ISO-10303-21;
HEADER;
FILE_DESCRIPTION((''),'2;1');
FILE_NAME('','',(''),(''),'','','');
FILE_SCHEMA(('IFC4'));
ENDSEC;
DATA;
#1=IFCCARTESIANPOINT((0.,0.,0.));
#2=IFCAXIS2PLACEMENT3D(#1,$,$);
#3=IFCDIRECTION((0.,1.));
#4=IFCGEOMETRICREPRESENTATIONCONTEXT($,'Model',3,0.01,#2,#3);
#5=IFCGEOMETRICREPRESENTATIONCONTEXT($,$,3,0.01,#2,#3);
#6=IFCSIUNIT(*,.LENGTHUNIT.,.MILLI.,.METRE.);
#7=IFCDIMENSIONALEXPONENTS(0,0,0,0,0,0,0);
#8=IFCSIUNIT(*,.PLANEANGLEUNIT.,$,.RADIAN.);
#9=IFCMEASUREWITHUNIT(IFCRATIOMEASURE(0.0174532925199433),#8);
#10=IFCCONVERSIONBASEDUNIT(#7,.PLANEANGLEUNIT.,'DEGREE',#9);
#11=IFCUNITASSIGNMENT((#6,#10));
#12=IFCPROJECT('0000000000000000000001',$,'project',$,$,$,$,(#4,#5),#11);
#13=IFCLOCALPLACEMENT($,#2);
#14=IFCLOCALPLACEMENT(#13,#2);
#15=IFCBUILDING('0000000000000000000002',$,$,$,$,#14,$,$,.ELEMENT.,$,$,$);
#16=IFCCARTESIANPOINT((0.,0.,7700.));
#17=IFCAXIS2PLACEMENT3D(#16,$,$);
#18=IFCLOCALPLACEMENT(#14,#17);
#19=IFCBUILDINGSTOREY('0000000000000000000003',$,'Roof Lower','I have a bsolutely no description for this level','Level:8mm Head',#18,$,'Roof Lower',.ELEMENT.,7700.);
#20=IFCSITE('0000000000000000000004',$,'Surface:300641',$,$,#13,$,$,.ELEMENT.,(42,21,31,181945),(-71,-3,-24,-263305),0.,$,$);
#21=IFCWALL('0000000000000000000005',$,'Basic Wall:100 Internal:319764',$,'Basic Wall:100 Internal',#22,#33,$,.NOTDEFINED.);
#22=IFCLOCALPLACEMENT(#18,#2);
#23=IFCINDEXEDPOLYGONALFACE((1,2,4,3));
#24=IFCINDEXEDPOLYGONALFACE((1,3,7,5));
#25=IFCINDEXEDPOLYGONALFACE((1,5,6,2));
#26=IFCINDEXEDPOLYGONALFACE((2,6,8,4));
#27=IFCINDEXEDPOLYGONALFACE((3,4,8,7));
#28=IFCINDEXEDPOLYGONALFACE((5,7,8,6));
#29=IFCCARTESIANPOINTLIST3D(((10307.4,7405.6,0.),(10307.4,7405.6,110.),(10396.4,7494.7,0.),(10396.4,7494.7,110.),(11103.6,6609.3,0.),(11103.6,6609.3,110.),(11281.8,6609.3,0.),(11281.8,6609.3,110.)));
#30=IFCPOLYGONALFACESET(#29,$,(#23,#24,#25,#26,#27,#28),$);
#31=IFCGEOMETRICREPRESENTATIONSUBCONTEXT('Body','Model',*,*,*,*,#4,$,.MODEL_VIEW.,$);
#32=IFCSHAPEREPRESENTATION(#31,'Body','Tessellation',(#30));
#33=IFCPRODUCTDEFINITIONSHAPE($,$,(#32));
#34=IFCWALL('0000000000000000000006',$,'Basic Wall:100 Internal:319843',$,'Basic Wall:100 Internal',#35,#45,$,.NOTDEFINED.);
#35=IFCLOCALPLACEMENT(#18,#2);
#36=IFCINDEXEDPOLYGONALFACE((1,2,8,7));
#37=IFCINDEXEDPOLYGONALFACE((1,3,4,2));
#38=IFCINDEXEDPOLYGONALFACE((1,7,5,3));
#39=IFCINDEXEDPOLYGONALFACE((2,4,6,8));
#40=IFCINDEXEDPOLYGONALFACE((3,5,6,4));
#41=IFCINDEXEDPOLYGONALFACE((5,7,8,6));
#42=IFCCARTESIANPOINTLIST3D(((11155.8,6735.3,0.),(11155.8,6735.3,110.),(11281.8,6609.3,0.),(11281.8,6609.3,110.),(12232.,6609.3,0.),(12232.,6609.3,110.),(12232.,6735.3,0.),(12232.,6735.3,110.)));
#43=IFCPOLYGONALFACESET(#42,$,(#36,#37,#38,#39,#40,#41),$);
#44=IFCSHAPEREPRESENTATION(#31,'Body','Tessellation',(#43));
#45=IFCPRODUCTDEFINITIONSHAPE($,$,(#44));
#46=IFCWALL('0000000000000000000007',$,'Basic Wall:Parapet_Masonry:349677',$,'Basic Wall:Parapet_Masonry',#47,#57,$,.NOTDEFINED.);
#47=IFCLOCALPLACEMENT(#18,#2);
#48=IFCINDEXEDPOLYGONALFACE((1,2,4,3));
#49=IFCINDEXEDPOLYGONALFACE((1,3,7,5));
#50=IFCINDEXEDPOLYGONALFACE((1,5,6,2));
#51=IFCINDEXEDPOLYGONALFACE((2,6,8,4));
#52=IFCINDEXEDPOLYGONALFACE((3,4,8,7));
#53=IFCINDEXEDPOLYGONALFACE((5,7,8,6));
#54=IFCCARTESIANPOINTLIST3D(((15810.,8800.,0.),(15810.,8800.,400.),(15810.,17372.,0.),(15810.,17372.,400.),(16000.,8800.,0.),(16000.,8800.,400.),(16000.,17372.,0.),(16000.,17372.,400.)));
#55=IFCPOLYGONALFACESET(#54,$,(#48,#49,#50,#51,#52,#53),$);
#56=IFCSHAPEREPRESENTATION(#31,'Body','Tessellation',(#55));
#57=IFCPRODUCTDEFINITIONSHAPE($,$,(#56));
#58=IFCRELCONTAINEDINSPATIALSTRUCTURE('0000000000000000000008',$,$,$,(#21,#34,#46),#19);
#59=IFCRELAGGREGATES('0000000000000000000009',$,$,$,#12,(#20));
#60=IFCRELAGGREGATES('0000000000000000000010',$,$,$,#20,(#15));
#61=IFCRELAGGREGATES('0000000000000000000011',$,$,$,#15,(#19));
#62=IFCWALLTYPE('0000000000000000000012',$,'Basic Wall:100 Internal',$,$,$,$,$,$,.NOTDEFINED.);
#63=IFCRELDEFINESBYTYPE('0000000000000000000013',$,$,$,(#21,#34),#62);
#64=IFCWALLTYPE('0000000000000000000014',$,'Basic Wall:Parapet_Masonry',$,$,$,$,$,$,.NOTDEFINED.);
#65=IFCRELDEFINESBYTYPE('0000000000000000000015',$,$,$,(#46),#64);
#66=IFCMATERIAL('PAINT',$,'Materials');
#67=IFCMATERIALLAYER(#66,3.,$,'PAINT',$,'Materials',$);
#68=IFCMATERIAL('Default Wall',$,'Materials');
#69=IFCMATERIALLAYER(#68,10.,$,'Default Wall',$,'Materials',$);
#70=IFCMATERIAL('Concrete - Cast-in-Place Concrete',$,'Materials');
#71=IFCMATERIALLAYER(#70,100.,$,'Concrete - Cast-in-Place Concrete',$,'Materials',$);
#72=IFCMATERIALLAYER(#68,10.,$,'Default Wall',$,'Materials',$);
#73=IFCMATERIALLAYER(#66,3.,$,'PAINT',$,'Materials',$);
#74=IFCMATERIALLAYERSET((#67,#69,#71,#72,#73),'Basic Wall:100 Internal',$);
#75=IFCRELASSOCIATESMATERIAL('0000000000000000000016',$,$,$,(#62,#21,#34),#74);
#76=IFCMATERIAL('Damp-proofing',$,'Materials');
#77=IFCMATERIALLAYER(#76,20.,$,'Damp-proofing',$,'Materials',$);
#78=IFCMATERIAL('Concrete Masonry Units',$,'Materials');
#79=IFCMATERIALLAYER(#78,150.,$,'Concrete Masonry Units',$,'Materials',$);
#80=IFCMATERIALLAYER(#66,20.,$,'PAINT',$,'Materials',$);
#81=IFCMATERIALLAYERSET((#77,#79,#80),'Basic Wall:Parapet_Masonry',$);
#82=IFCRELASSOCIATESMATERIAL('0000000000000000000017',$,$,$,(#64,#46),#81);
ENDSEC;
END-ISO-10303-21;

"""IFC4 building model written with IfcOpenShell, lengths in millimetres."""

from ifc_helpers import new_model, entity, si_unit, converted_unit, direction, frame, frame_2d, origin, place, context, subcontext, project, spatial, polyline, rectangle, outline, extrude, clip, halfspace, bounded_halfspace, material, layer, layer_set, layer_usage, type_object, element, save


model = new_model("IFC4")

# Units and contexts
model_context = context("Model", 3, precision=0.01, world=origin(), true_north=direction((0.0, 1.0)))
context_of_model = context(None, 3, precision=0.01, world=origin(), true_north=direction((0.0, 1.0)))
body_context = subcontext(model_context, "Body", "Model", "MODEL_VIEW")
ifc_project = project(units=[si_unit("LENGTHUNIT", "METRE", prefix="MILLI"), converted_unit("PLANEANGLEUNIT", "DEGREE", entity("IfcRatioMeasure", 0.0174532925199433), si_unit("PLANEANGLEUNIT", "RADIAN"), dimensions=[0, 0, 0, 0, 0, 0, 0])], contexts=[model_context, context_of_model])

# Site, building, storey
site_placement = place(None, origin())
site = spatial("IfcSite", under=ifc_project, at=site_placement, Name="Surface:300641", CompositionType="ELEMENT", RefLatitude=(42, 21, 31, 181945), RefLongitude=(-71, -3, -24, -263305), RefElevation=0.0)
building_placement = place(site_placement, origin())
building = spatial("IfcBuilding", under=site, at=building_placement, CompositionType="ELEMENT")
storey_placement = place(building_placement, frame((0.0, 0.0, 7700.0)))
storey = spatial("IfcBuildingStorey", under=building, at=storey_placement, Name="Roof Lower", Description="I have a bsolutely no description for this level", ObjectType="Level:8mm Head", LongName="Roof Lower", CompositionType="ELEMENT", Elevation=7700.0)

# Shared definitions
ifc_material_1 = material(Name="Concrete - Cast-in-Place Concrete", Category="Materials")

# Shared definitions
ifc_material_2 = material(Name="Damp-proofing", Category="Materials")

# Walls
ifc_material_3 = material(Name="PAINT", Category="Materials")
ifc_material_4 = material(Name="Default Wall", Category="Materials")
ifc_layer_1 = layer(ifc_material_3, 3.0, Name="PAINT", Category="Materials")
ifc_layer_2 = layer(ifc_material_4, 10.0, Name="Default Wall", Category="Materials")
ifc_layer_3 = layer(ifc_material_1, 100.0, Name="Concrete - Cast-in-Place Concrete", Category="Materials")
ifc_layer_4 = layer(ifc_material_4, 10.0, Name="Default Wall", Category="Materials")
ifc_layer_5 = layer(ifc_material_3, 3.0, Name="PAINT", Category="Materials")
ifc_layer_set_1 = layer_set([ifc_layer_1, ifc_layer_2, ifc_layer_3, ifc_layer_4, ifc_layer_5], Name="Basic Wall:100 Internal")
wall_type_1 = type_object("IfcWallType", Name="Basic Wall:100 Internal", PredefinedType="NOTDEFINED", material=ifc_layer_set_1)
ifc_layer_usage_1 = layer_usage(ifc_layer_set_1, "AXIS2", "NEGATIVE", 63.0)
wall_1_placement = place(storey_placement, frame((10351.9, 7450.1, 0.0), z_axis=(0.0, 0.0, 1.0), x_axis=(0.707107, -0.707107, 0.0)))
element("IfcWall", 1, at=wall_1_placement, inside=storey, type_object=wall_type_1, material=ifc_layer_usage_1, Name="Basic Wall:100 Internal:319764", ObjectType="Basic Wall:100 Internal", PredefinedType="NOTDEFINED", context=body_context, shape_type="Clipping", body=[
    clip(clip(extrude(outline(polyline([(1126.1, -63.0), (1252.1, 63.0), (1073.9, 63.0), (0.0, 63.0), (0.0, -63.0), (1126.1, -63.0)])), origin(), (0.0, 0.0, 1.0), 110.0), bounded_halfspace(frame((0.0, -63.0, 110.0), z_axis=(0.0, 0.0, -1.0), x_axis=(0.707107, 0.707107, 0.0)), True, frame((0.0, -63.0, 110.0)), polyline([(0.0, 0.0), (1126.1, 0.0), (1252.1, 126.0), (1073.9, 126.0), (0.0, 126.0), (0.0, 0.0)]))), halfspace(frame((0.0, 0.0, -3500.0)), True)),
])
ifc_layer_usage_2 = layer_usage(ifc_layer_set_1, "AXIS2", "NEGATIVE", 63.0)
wall_2_placement = place(storey_placement, frame((11155.8, 6672.3, 0.0)))
element("IfcWall", 2, at=wall_2_placement, inside=storey, type_object=wall_type_1, material=ifc_layer_usage_2, Name="Basic Wall:100 Internal:319843", ObjectType="Basic Wall:100 Internal", PredefinedType="NOTDEFINED", context=body_context, shape_type="Clipping", body=[
    clip(clip(extrude(outline(polyline([(126.0, -63.0), (1076.2, -63.0), (1076.2, 63.0), (0.0, 63.0), (126.0, -63.0)])), origin(), (0.0, 0.0, 1.0), 110.0), bounded_halfspace(frame((126.0, -63.0, 110.0), z_axis=(0.0, 0.0, -1.0), x_axis=(1.0, 0.0, 0.0)), True, frame((126.0, -63.0, 110.0)), polyline([(0.0, 0.0), (950.2, 0.0), (950.2, 126.0), (-126.0, 126.0), (0.0, 0.0)]))), halfspace(frame((0.0, 0.0, -3500.0)), True)),
])
ifc_layer_6 = layer(ifc_material_2, 20.0, Name="Damp-proofing", Category="Materials")
ifc_material_5 = material(Name="Concrete Masonry Units", Category="Materials")
ifc_layer_7 = layer(ifc_material_5, 150.0, Name="Concrete Masonry Units", Category="Materials")
ifc_layer_8 = layer(ifc_material_3, 20.0, Name="PAINT", Category="Materials")
ifc_layer_set_2 = layer_set([ifc_layer_6, ifc_layer_7, ifc_layer_8], Name="Basic Wall:Parapet_Masonry")
ifc_layer_usage_3 = layer_usage(ifc_layer_set_2, "AXIS2", "NEGATIVE", 95.0)
wall_type_2 = type_object("IfcWallType", Name="Basic Wall:Parapet_Masonry", PredefinedType="NOTDEFINED", material=ifc_layer_set_2)
wall_3_placement = place(storey_placement, frame((15905.0, 8800.0, 0.0), z_axis=(0.0, 0.0, 1.0), x_axis=(0.0, 1.0, 0.0)))
element("IfcWall", 3, at=wall_3_placement, inside=storey, type_object=wall_type_2, material=ifc_layer_usage_3, Name="Basic Wall:Parapet_Masonry:349677", ObjectType="Basic Wall:Parapet_Masonry", PredefinedType="NOTDEFINED", context=body_context, shape_type="Clipping", body=[
    clip(extrude(rectangle(XDim=8572.0, YDim=190.0, at=frame_2d((4286.0, 0.0), x_axis=(-1.0, 0.0))), origin(), (0.0, 0.0, 1.0), 400.0), halfspace(origin(), True)),
])

save(model, "model.ifc")
